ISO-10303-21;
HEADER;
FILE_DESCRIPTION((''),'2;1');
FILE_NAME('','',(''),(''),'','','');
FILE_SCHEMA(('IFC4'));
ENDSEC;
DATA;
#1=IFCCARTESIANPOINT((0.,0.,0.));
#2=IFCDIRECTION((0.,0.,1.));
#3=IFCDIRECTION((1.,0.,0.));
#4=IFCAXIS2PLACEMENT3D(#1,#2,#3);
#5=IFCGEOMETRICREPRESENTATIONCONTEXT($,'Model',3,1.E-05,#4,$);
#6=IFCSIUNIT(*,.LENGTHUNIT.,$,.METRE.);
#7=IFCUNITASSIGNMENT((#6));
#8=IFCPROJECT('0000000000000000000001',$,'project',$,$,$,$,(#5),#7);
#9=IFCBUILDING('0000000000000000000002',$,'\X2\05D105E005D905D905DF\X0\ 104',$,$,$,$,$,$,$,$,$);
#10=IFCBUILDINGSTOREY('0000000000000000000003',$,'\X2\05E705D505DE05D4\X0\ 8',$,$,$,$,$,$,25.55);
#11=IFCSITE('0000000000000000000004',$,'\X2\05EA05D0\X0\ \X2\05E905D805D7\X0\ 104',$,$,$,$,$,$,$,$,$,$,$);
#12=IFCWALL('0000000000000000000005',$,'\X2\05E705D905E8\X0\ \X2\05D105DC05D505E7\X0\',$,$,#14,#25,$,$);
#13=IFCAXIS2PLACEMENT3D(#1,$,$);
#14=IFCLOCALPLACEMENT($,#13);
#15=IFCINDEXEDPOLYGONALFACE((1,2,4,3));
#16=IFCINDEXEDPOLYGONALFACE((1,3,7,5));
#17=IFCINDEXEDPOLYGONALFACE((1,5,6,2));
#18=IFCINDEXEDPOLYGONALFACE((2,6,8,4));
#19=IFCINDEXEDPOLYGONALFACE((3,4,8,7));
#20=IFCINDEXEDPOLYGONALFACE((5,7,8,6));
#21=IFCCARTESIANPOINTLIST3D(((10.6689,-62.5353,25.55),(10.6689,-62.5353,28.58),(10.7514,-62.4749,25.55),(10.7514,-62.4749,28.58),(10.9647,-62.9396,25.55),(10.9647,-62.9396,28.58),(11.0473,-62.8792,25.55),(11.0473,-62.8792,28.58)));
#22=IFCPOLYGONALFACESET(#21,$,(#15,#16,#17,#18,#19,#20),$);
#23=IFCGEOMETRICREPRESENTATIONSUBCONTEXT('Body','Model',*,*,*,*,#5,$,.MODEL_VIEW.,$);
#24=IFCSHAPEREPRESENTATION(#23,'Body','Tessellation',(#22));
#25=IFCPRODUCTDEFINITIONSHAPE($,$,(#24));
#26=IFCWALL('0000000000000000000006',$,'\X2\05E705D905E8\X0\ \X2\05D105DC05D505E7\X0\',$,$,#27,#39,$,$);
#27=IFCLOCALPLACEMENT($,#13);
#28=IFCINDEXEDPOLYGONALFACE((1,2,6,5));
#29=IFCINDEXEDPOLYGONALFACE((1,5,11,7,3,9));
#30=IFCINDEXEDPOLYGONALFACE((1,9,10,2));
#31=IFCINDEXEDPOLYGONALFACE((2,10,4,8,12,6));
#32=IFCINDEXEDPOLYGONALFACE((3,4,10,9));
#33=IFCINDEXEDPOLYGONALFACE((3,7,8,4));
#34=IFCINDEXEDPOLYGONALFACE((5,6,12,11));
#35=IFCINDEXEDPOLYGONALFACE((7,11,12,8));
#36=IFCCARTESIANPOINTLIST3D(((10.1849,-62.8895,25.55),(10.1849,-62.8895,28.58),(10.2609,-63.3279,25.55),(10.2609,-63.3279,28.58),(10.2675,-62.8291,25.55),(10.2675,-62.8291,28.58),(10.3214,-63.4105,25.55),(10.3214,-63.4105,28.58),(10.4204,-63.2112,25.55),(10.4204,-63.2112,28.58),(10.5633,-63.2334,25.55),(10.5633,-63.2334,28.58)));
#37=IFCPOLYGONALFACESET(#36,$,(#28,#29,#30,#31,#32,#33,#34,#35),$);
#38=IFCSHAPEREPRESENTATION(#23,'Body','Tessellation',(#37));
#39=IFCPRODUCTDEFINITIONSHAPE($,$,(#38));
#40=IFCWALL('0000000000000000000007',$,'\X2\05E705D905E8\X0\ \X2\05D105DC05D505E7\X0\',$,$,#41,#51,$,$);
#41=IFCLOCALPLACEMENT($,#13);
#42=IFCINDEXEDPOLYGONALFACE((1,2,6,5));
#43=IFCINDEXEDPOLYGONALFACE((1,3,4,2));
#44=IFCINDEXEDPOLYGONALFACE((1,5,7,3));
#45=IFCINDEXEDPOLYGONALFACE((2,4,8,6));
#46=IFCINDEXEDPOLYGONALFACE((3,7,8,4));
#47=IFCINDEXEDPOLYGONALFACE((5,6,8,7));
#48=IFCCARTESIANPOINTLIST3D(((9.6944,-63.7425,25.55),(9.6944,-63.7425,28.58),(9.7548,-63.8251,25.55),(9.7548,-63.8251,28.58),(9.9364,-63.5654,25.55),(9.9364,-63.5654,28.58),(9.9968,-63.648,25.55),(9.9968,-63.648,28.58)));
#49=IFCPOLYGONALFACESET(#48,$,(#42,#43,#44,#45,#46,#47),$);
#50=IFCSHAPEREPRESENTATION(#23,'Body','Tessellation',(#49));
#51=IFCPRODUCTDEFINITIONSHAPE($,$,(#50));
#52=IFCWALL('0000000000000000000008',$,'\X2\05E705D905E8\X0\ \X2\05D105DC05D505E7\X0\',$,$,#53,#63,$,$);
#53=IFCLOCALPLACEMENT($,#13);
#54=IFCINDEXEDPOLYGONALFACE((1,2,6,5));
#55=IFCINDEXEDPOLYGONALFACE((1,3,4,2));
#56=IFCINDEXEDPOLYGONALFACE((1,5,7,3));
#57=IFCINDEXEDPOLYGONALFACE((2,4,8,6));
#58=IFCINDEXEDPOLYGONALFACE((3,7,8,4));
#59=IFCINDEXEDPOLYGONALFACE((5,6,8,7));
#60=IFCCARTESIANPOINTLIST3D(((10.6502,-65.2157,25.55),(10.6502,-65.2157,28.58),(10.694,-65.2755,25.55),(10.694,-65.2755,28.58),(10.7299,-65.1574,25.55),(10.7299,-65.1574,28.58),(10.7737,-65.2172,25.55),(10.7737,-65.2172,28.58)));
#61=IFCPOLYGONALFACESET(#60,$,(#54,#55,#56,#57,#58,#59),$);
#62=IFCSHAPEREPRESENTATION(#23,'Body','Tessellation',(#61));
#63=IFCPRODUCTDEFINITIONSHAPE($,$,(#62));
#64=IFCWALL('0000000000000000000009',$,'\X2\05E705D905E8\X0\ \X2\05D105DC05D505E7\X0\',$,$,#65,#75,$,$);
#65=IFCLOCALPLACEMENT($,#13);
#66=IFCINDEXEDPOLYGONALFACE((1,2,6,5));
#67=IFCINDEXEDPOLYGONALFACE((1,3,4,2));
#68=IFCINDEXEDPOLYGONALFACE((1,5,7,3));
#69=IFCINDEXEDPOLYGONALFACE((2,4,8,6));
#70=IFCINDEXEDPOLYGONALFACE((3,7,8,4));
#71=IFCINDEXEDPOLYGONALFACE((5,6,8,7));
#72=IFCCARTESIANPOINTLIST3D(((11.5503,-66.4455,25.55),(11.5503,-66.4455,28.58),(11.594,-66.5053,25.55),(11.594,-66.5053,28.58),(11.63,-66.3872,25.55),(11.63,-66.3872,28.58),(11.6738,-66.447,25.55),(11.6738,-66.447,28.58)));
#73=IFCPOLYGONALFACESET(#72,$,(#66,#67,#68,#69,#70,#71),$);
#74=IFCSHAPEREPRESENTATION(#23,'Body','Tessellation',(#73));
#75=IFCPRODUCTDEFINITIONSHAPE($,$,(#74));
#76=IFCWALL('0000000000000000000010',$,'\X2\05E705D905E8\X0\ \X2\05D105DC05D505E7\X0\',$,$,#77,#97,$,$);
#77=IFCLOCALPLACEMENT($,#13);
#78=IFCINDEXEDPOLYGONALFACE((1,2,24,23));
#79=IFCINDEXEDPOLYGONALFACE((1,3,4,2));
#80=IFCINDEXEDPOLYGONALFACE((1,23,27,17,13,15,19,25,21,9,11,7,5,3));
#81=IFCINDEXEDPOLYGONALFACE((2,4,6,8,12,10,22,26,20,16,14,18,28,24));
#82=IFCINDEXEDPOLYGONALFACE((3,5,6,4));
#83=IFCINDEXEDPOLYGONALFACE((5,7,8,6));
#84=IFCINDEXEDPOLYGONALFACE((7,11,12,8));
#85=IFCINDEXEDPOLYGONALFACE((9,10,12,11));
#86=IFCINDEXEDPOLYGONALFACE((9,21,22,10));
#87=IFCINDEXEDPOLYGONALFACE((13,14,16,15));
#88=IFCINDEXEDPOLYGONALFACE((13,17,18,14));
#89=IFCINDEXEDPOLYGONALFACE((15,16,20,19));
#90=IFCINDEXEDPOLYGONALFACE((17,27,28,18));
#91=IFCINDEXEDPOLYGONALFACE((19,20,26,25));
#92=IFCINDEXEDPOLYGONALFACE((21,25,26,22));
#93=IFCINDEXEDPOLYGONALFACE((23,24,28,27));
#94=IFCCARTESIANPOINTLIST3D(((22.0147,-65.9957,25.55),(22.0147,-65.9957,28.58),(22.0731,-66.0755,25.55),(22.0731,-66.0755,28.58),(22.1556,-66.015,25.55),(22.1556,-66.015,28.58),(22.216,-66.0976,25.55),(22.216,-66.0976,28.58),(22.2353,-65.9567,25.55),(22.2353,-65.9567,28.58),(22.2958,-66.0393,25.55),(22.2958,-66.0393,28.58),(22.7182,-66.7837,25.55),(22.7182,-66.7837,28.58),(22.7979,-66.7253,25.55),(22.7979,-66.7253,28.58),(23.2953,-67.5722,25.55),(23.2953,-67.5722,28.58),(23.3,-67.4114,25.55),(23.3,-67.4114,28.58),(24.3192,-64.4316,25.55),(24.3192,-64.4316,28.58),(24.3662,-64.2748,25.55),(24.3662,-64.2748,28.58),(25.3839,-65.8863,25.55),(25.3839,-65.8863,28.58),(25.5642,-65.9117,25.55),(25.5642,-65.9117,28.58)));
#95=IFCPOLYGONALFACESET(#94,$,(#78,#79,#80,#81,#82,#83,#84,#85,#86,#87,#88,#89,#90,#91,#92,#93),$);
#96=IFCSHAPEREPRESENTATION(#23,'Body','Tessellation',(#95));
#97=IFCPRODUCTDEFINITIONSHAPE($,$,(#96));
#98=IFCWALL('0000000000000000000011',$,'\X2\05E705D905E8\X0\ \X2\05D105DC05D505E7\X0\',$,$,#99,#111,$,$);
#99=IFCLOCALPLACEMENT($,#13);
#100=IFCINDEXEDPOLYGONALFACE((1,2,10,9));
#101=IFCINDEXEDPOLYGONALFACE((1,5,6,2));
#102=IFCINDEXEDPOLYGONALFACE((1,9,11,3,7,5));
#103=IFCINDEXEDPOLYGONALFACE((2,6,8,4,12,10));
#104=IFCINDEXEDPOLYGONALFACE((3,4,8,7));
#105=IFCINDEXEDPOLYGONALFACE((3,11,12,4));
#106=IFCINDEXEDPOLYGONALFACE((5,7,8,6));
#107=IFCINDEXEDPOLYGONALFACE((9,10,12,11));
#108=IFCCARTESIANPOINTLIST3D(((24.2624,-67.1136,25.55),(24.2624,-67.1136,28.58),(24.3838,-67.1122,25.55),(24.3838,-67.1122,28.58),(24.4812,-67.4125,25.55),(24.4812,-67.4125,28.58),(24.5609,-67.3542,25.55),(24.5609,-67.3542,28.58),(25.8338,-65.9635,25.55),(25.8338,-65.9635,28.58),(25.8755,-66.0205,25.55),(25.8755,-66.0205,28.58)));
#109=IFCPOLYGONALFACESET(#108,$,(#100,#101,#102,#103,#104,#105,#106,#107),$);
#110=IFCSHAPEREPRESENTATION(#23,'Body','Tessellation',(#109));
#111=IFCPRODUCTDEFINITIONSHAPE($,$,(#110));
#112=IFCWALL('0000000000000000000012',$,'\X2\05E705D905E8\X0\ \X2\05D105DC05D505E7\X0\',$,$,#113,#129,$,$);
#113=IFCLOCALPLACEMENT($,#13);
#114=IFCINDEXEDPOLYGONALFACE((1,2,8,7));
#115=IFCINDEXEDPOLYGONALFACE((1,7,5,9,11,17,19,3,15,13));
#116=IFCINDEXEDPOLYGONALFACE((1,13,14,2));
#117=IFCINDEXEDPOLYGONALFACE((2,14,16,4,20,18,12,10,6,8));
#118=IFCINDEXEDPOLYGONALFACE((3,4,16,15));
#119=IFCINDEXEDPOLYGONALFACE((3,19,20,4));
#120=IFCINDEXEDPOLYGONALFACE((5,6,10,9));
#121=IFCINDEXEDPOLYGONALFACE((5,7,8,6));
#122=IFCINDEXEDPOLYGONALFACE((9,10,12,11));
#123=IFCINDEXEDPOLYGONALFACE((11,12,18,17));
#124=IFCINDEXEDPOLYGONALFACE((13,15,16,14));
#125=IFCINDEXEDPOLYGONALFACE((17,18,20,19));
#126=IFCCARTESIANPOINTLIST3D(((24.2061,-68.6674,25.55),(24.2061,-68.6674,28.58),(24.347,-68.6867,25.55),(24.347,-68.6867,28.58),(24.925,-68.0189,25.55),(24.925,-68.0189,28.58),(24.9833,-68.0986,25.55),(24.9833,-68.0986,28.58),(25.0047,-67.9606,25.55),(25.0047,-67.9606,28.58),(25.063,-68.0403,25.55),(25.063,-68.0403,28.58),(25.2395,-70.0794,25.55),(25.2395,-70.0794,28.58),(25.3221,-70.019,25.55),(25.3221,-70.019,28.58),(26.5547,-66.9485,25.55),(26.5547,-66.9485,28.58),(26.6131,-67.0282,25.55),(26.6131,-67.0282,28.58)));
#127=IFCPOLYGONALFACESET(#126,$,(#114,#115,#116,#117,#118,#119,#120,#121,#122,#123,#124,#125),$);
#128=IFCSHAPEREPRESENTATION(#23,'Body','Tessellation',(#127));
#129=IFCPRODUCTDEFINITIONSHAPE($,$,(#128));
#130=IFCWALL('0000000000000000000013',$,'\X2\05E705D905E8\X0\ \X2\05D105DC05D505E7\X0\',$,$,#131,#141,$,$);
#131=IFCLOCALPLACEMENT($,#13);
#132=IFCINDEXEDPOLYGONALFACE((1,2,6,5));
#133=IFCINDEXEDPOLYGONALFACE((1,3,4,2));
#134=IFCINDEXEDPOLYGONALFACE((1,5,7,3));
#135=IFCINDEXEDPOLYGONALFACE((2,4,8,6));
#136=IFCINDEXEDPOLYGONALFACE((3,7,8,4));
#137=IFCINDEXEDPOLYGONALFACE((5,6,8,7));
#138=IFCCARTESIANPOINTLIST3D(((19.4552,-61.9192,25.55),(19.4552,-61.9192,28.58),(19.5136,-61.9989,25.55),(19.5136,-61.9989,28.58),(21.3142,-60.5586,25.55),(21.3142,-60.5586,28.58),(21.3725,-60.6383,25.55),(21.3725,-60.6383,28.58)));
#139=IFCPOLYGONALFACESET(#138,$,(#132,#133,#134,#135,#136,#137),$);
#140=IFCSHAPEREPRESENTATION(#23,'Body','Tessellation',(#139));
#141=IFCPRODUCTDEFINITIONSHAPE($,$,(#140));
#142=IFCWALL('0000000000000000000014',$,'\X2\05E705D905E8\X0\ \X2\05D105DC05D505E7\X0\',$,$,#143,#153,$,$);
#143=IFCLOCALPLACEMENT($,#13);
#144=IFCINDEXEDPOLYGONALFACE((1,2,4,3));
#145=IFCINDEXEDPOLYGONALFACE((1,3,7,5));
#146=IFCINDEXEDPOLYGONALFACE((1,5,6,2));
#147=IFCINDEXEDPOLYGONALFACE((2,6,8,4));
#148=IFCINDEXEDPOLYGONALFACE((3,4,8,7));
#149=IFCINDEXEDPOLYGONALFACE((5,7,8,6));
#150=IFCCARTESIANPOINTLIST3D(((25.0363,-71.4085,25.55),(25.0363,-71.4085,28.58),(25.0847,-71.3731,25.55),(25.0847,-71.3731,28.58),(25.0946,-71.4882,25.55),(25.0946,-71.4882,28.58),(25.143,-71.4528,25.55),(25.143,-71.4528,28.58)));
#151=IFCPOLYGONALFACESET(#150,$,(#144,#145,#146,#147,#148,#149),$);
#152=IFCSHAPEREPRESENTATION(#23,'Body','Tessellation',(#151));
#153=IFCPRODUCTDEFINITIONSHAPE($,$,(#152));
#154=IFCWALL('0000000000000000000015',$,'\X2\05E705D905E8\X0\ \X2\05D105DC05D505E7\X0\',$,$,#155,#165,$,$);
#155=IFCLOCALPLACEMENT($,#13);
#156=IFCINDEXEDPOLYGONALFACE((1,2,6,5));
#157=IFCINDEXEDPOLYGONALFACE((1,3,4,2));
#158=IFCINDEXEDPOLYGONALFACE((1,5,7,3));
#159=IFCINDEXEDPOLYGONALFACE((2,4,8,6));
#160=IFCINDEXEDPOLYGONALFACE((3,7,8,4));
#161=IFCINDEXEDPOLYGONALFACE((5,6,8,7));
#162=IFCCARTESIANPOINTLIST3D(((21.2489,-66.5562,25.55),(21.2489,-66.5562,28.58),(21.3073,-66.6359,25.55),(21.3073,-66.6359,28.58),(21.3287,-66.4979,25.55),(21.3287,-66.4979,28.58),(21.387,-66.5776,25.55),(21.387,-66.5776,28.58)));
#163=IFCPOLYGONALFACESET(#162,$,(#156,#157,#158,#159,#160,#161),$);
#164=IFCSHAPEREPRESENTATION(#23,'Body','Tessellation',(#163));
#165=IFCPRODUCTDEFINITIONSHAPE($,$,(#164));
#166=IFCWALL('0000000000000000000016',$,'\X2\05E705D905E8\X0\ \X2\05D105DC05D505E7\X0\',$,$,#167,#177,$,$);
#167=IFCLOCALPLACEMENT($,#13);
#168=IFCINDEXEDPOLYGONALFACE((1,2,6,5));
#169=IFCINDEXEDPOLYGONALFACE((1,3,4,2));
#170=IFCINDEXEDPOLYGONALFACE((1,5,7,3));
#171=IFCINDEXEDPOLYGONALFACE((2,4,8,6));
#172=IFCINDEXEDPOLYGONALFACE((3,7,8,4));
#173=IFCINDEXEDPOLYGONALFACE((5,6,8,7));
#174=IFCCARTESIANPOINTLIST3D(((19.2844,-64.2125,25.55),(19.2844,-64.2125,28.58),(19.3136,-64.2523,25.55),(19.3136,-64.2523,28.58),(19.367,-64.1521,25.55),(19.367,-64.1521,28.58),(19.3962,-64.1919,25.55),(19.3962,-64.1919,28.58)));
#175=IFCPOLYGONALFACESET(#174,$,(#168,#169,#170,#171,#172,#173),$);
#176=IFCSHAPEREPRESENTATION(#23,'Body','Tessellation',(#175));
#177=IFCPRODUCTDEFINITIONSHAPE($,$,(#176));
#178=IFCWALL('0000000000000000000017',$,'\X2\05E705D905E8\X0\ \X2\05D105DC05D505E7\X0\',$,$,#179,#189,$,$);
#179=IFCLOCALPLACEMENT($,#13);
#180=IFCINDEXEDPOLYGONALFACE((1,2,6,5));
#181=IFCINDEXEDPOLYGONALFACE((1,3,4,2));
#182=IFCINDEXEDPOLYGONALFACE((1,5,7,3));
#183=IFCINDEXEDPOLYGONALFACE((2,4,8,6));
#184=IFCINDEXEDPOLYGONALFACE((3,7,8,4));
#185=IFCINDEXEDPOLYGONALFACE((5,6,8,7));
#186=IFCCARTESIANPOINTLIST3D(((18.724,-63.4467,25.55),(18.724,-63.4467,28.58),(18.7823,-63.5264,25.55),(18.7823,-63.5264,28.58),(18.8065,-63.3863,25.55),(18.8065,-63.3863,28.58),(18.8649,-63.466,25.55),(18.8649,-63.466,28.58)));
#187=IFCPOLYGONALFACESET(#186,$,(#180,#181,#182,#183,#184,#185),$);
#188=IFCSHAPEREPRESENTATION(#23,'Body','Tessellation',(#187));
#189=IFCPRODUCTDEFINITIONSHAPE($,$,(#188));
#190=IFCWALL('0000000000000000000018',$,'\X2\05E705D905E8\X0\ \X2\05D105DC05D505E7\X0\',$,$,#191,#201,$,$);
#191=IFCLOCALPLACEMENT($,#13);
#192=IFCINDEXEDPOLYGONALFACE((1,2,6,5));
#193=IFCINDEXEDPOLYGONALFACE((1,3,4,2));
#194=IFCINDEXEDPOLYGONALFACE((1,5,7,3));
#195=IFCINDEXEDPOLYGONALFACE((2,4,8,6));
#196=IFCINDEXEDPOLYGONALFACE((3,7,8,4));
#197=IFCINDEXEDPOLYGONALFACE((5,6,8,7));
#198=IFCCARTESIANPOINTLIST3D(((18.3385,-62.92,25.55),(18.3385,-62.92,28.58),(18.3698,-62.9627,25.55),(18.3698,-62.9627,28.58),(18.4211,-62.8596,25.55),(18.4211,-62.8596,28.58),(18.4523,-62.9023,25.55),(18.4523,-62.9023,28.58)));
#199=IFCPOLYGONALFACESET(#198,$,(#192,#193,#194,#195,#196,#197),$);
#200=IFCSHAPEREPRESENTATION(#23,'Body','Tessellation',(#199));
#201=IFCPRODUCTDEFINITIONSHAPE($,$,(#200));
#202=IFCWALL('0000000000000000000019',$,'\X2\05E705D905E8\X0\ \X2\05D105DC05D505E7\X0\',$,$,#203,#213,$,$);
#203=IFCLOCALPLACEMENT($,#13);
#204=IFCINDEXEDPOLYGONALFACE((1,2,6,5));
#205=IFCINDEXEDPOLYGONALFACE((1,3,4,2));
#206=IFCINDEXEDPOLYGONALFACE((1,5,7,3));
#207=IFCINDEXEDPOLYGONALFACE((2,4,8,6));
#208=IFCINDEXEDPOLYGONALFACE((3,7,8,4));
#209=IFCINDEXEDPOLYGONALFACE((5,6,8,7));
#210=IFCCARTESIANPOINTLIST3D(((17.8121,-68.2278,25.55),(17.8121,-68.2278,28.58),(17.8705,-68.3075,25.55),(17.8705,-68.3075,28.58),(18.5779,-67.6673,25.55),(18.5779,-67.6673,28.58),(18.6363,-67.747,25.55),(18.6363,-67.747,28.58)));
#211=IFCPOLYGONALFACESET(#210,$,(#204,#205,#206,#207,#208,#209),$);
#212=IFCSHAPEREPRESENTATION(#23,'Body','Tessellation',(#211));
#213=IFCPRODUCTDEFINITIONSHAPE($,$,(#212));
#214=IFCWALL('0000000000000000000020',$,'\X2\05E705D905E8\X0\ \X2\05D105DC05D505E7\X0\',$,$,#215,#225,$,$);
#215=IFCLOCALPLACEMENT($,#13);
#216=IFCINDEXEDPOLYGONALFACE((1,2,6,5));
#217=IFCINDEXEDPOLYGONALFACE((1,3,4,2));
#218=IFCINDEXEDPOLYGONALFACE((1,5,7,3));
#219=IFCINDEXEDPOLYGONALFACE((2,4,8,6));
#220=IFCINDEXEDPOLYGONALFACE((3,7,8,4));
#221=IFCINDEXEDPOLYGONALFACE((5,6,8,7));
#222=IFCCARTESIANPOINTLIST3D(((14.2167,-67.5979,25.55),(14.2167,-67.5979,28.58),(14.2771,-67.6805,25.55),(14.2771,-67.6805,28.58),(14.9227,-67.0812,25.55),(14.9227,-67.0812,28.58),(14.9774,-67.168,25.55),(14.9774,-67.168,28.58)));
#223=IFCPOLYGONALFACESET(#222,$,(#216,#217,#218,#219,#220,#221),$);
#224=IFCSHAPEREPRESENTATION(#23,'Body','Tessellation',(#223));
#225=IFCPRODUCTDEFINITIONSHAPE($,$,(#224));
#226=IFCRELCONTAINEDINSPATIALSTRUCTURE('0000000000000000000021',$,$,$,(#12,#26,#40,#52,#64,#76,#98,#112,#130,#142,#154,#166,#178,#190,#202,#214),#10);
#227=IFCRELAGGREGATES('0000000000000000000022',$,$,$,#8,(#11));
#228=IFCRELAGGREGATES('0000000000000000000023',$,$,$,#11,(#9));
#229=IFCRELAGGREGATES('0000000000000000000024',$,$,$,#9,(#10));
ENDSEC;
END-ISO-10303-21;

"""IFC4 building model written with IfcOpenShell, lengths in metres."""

from ifc_helpers import new_model, si_unit, frame, origin_with_axes, context, subcontext, project, spatial, polyline, outline, extrude, element, save


model = new_model("IFC4")

# Units and contexts
model_context = context("Model", 3, precision=1e-05, world=origin_with_axes())
body_context = subcontext(model_context, "Body", "Model", "MODEL_VIEW")
ifc_project = project(units=[si_unit("LENGTHUNIT", "METRE")], contexts=[model_context])

# Site, building, storey
site = spatial("IfcSite", under=ifc_project, Name="תא שטח 104")
building = spatial("IfcBuilding", under=site, Name="בניין 104")
storey = spatial("IfcBuildingStorey", under=building, Name="קומה 8", Elevation=25.55)

# Walls
element("IfcWall", 1, inside=storey, Name="קיר בלוק", context=body_context, shape_type="SweptSolid", body=[
    extrude(outline(polyline([(10.6689, -62.5353), (10.9647, -62.9396), (11.0473, -62.8792), (10.7514, -62.4749), (10.6689, -62.5353)])), frame((0.0, 0.0, 25.55)), (0.0, 0.0, 1.0), 3.03),
])
element("IfcWall", 2, inside=storey, Name="קיר בלוק", context=body_context, shape_type="SweptSolid", body=[
    extrude(outline(polyline([(10.2675, -62.8291), (10.1849, -62.8895), (10.4204, -63.2112), (10.2609, -63.3279), (10.3214, -63.4105), (10.5633, -63.2334), (10.2675, -62.8291)])), frame((0.0, 0.0, 25.55)), (0.0, 0.0, 1.0), 3.03),
])
element("IfcWall", 3, inside=storey, Name="קיר בלוק", context=body_context, shape_type="SweptSolid", body=[
    extrude(outline(polyline([(9.9968, -63.648), (9.9364, -63.5654), (9.6944, -63.7425), (9.7548, -63.8251), (9.9968, -63.648)])), frame((0.0, 0.0, 25.55)), (0.0, 0.0, 1.0), 3.03),
])
element("IfcWall", 4, inside=storey, Name="קיר בלוק", context=body_context, shape_type="SweptSolid", body=[
    extrude(outline(polyline([(10.7299, -65.1574), (10.6502, -65.2157), (10.694, -65.2755), (10.7737, -65.2172), (10.7299, -65.1574)])), frame((0.0, 0.0, 25.55)), (0.0, 0.0, 1.0), 3.03),
])
element("IfcWall", 5, inside=storey, Name="קיר בלוק", context=body_context, shape_type="SweptSolid", body=[
    extrude(outline(polyline([(11.6738, -66.447), (11.63, -66.3872), (11.5503, -66.4455), (11.594, -66.5053), (11.6738, -66.447)])), frame((0.0, 0.0, 25.55)), (0.0, 0.0, 1.0), 3.03),
])
element("IfcWall", 6, inside=storey, Name="קיר בלוק", context=body_context, shape_type="SweptSolid", body=[
    extrude(outline(polyline([(22.7182, -66.7837), (23.2953, -67.5722), (25.5642, -65.9117), (24.3662, -64.2748), (22.0147, -65.9957), (22.0731, -66.0755), (22.1556, -66.015), (22.216, -66.0976), (22.2958, -66.0393), (22.2353, -65.9567), (24.3192, -64.4316), (25.3839, -65.8863), (23.3, -67.4114), (22.7979, -66.7253), (22.7182, -66.7837)])), frame((0.0, 0.0, 25.55)), (0.0, 0.0, 1.0), 3.03),
])
element("IfcWall", 7, inside=storey, Name="קיר בלוק", context=body_context, shape_type="SweptSolid", body=[
    extrude(outline(polyline([(24.2624, -67.1136), (24.4812, -67.4125), (24.5609, -67.3542), (24.3838, -67.1122), (25.8755, -66.0205), (25.8338, -65.9635), (24.2624, -67.1136)])), frame((0.0, 0.0, 25.55)), (0.0, 0.0, 1.0), 3.03),
])
element("IfcWall", 8, inside=storey, Name="קיר בלוק", context=body_context, shape_type="SweptSolid", body=[
    extrude(outline(polyline([(24.925, -68.0189), (24.9833, -68.0986), (24.2061, -68.6674), (25.2395, -70.0794), (25.3221, -70.019), (24.347, -68.6867), (26.6131, -67.0282), (26.5547, -66.9485), (25.063, -68.0403), (25.0047, -67.9606), (24.925, -68.0189)])), frame((0.0, 0.0, 25.55)), (0.0, 0.0, 1.0), 3.03),
])
element("IfcWall", 9, inside=storey, Name="קיר בלוק", context=body_context, shape_type="SweptSolid", body=[
    extrude(outline(polyline([(21.3142, -60.5586), (19.4552, -61.9192), (19.5136, -61.9989), (21.3725, -60.6383), (21.3142, -60.5586)])), frame((0.0, 0.0, 25.55)), (0.0, 0.0, 1.0), 3.03),
])
element("IfcWall", 10, inside=storey, Name="קיר בלוק", context=body_context, shape_type="SweptSolid", body=[
    extrude(outline(polyline([(25.0946, -71.4882), (25.143, -71.4528), (25.0847, -71.3731), (25.0363, -71.4085), (25.0946, -71.4882)])), frame((0.0, 0.0, 25.55)), (0.0, 0.0, 1.0), 3.03),
])
element("IfcWall", 11, inside=storey, Name="קיר בלוק", context=body_context, shape_type="SweptSolid", body=[
    extrude(outline(polyline([(21.387, -66.5776), (21.3287, -66.4979), (21.2489, -66.5562), (21.3073, -66.6359), (21.387, -66.5776)])), frame((0.0, 0.0, 25.55)), (0.0, 0.0, 1.0), 3.03),
])
element("IfcWall", 12, inside=storey, Name="קיר בלוק", context=body_context, shape_type="SweptSolid", body=[
    extrude(outline(polyline([(19.2844, -64.2125), (19.3136, -64.2523), (19.3962, -64.1919), (19.367, -64.1521), (19.2844, -64.2125)])), frame((0.0, 0.0, 25.55)), (0.0, 0.0, 1.0), 3.03),
])
element("IfcWall", 13, inside=storey, Name="קיר בלוק", context=body_context, shape_type="SweptSolid", body=[
    extrude(outline(polyline([(18.8065, -63.3863), (18.724, -63.4467), (18.7823, -63.5264), (18.8649, -63.466), (18.8065, -63.3863)])), frame((0.0, 0.0, 25.55)), (0.0, 0.0, 1.0), 3.03),
])
element("IfcWall", 14, inside=storey, Name="קיר בלוק", context=body_context, shape_type="SweptSolid", body=[
    extrude(outline(polyline([(18.4523, -62.9023), (18.4211, -62.8596), (18.3385, -62.92), (18.3698, -62.9627), (18.4523, -62.9023)])), frame((0.0, 0.0, 25.55)), (0.0, 0.0, 1.0), 3.03),
])
element("IfcWall", 15, inside=storey, Name="קיר בלוק", context=body_context, shape_type="SweptSolid", body=[
    extrude(outline(polyline([(17.8121, -68.2278), (17.8705, -68.3075), (18.6363, -67.747), (18.5779, -67.6673), (17.8121, -68.2278)])), frame((0.0, 0.0, 25.55)), (0.0, 0.0, 1.0), 3.03),
])
element("IfcWall", 16, inside=storey, Name="קיר בלוק", context=body_context, shape_type="SweptSolid", body=[
    extrude(outline(polyline([(14.9227, -67.0812), (14.2167, -67.5979), (14.2771, -67.6805), (14.9774, -67.168), (14.9227, -67.0812)])), frame((0.0, 0.0, 25.55)), (0.0, 0.0, 1.0), 3.03),
])

save(model, "model.ifc")
